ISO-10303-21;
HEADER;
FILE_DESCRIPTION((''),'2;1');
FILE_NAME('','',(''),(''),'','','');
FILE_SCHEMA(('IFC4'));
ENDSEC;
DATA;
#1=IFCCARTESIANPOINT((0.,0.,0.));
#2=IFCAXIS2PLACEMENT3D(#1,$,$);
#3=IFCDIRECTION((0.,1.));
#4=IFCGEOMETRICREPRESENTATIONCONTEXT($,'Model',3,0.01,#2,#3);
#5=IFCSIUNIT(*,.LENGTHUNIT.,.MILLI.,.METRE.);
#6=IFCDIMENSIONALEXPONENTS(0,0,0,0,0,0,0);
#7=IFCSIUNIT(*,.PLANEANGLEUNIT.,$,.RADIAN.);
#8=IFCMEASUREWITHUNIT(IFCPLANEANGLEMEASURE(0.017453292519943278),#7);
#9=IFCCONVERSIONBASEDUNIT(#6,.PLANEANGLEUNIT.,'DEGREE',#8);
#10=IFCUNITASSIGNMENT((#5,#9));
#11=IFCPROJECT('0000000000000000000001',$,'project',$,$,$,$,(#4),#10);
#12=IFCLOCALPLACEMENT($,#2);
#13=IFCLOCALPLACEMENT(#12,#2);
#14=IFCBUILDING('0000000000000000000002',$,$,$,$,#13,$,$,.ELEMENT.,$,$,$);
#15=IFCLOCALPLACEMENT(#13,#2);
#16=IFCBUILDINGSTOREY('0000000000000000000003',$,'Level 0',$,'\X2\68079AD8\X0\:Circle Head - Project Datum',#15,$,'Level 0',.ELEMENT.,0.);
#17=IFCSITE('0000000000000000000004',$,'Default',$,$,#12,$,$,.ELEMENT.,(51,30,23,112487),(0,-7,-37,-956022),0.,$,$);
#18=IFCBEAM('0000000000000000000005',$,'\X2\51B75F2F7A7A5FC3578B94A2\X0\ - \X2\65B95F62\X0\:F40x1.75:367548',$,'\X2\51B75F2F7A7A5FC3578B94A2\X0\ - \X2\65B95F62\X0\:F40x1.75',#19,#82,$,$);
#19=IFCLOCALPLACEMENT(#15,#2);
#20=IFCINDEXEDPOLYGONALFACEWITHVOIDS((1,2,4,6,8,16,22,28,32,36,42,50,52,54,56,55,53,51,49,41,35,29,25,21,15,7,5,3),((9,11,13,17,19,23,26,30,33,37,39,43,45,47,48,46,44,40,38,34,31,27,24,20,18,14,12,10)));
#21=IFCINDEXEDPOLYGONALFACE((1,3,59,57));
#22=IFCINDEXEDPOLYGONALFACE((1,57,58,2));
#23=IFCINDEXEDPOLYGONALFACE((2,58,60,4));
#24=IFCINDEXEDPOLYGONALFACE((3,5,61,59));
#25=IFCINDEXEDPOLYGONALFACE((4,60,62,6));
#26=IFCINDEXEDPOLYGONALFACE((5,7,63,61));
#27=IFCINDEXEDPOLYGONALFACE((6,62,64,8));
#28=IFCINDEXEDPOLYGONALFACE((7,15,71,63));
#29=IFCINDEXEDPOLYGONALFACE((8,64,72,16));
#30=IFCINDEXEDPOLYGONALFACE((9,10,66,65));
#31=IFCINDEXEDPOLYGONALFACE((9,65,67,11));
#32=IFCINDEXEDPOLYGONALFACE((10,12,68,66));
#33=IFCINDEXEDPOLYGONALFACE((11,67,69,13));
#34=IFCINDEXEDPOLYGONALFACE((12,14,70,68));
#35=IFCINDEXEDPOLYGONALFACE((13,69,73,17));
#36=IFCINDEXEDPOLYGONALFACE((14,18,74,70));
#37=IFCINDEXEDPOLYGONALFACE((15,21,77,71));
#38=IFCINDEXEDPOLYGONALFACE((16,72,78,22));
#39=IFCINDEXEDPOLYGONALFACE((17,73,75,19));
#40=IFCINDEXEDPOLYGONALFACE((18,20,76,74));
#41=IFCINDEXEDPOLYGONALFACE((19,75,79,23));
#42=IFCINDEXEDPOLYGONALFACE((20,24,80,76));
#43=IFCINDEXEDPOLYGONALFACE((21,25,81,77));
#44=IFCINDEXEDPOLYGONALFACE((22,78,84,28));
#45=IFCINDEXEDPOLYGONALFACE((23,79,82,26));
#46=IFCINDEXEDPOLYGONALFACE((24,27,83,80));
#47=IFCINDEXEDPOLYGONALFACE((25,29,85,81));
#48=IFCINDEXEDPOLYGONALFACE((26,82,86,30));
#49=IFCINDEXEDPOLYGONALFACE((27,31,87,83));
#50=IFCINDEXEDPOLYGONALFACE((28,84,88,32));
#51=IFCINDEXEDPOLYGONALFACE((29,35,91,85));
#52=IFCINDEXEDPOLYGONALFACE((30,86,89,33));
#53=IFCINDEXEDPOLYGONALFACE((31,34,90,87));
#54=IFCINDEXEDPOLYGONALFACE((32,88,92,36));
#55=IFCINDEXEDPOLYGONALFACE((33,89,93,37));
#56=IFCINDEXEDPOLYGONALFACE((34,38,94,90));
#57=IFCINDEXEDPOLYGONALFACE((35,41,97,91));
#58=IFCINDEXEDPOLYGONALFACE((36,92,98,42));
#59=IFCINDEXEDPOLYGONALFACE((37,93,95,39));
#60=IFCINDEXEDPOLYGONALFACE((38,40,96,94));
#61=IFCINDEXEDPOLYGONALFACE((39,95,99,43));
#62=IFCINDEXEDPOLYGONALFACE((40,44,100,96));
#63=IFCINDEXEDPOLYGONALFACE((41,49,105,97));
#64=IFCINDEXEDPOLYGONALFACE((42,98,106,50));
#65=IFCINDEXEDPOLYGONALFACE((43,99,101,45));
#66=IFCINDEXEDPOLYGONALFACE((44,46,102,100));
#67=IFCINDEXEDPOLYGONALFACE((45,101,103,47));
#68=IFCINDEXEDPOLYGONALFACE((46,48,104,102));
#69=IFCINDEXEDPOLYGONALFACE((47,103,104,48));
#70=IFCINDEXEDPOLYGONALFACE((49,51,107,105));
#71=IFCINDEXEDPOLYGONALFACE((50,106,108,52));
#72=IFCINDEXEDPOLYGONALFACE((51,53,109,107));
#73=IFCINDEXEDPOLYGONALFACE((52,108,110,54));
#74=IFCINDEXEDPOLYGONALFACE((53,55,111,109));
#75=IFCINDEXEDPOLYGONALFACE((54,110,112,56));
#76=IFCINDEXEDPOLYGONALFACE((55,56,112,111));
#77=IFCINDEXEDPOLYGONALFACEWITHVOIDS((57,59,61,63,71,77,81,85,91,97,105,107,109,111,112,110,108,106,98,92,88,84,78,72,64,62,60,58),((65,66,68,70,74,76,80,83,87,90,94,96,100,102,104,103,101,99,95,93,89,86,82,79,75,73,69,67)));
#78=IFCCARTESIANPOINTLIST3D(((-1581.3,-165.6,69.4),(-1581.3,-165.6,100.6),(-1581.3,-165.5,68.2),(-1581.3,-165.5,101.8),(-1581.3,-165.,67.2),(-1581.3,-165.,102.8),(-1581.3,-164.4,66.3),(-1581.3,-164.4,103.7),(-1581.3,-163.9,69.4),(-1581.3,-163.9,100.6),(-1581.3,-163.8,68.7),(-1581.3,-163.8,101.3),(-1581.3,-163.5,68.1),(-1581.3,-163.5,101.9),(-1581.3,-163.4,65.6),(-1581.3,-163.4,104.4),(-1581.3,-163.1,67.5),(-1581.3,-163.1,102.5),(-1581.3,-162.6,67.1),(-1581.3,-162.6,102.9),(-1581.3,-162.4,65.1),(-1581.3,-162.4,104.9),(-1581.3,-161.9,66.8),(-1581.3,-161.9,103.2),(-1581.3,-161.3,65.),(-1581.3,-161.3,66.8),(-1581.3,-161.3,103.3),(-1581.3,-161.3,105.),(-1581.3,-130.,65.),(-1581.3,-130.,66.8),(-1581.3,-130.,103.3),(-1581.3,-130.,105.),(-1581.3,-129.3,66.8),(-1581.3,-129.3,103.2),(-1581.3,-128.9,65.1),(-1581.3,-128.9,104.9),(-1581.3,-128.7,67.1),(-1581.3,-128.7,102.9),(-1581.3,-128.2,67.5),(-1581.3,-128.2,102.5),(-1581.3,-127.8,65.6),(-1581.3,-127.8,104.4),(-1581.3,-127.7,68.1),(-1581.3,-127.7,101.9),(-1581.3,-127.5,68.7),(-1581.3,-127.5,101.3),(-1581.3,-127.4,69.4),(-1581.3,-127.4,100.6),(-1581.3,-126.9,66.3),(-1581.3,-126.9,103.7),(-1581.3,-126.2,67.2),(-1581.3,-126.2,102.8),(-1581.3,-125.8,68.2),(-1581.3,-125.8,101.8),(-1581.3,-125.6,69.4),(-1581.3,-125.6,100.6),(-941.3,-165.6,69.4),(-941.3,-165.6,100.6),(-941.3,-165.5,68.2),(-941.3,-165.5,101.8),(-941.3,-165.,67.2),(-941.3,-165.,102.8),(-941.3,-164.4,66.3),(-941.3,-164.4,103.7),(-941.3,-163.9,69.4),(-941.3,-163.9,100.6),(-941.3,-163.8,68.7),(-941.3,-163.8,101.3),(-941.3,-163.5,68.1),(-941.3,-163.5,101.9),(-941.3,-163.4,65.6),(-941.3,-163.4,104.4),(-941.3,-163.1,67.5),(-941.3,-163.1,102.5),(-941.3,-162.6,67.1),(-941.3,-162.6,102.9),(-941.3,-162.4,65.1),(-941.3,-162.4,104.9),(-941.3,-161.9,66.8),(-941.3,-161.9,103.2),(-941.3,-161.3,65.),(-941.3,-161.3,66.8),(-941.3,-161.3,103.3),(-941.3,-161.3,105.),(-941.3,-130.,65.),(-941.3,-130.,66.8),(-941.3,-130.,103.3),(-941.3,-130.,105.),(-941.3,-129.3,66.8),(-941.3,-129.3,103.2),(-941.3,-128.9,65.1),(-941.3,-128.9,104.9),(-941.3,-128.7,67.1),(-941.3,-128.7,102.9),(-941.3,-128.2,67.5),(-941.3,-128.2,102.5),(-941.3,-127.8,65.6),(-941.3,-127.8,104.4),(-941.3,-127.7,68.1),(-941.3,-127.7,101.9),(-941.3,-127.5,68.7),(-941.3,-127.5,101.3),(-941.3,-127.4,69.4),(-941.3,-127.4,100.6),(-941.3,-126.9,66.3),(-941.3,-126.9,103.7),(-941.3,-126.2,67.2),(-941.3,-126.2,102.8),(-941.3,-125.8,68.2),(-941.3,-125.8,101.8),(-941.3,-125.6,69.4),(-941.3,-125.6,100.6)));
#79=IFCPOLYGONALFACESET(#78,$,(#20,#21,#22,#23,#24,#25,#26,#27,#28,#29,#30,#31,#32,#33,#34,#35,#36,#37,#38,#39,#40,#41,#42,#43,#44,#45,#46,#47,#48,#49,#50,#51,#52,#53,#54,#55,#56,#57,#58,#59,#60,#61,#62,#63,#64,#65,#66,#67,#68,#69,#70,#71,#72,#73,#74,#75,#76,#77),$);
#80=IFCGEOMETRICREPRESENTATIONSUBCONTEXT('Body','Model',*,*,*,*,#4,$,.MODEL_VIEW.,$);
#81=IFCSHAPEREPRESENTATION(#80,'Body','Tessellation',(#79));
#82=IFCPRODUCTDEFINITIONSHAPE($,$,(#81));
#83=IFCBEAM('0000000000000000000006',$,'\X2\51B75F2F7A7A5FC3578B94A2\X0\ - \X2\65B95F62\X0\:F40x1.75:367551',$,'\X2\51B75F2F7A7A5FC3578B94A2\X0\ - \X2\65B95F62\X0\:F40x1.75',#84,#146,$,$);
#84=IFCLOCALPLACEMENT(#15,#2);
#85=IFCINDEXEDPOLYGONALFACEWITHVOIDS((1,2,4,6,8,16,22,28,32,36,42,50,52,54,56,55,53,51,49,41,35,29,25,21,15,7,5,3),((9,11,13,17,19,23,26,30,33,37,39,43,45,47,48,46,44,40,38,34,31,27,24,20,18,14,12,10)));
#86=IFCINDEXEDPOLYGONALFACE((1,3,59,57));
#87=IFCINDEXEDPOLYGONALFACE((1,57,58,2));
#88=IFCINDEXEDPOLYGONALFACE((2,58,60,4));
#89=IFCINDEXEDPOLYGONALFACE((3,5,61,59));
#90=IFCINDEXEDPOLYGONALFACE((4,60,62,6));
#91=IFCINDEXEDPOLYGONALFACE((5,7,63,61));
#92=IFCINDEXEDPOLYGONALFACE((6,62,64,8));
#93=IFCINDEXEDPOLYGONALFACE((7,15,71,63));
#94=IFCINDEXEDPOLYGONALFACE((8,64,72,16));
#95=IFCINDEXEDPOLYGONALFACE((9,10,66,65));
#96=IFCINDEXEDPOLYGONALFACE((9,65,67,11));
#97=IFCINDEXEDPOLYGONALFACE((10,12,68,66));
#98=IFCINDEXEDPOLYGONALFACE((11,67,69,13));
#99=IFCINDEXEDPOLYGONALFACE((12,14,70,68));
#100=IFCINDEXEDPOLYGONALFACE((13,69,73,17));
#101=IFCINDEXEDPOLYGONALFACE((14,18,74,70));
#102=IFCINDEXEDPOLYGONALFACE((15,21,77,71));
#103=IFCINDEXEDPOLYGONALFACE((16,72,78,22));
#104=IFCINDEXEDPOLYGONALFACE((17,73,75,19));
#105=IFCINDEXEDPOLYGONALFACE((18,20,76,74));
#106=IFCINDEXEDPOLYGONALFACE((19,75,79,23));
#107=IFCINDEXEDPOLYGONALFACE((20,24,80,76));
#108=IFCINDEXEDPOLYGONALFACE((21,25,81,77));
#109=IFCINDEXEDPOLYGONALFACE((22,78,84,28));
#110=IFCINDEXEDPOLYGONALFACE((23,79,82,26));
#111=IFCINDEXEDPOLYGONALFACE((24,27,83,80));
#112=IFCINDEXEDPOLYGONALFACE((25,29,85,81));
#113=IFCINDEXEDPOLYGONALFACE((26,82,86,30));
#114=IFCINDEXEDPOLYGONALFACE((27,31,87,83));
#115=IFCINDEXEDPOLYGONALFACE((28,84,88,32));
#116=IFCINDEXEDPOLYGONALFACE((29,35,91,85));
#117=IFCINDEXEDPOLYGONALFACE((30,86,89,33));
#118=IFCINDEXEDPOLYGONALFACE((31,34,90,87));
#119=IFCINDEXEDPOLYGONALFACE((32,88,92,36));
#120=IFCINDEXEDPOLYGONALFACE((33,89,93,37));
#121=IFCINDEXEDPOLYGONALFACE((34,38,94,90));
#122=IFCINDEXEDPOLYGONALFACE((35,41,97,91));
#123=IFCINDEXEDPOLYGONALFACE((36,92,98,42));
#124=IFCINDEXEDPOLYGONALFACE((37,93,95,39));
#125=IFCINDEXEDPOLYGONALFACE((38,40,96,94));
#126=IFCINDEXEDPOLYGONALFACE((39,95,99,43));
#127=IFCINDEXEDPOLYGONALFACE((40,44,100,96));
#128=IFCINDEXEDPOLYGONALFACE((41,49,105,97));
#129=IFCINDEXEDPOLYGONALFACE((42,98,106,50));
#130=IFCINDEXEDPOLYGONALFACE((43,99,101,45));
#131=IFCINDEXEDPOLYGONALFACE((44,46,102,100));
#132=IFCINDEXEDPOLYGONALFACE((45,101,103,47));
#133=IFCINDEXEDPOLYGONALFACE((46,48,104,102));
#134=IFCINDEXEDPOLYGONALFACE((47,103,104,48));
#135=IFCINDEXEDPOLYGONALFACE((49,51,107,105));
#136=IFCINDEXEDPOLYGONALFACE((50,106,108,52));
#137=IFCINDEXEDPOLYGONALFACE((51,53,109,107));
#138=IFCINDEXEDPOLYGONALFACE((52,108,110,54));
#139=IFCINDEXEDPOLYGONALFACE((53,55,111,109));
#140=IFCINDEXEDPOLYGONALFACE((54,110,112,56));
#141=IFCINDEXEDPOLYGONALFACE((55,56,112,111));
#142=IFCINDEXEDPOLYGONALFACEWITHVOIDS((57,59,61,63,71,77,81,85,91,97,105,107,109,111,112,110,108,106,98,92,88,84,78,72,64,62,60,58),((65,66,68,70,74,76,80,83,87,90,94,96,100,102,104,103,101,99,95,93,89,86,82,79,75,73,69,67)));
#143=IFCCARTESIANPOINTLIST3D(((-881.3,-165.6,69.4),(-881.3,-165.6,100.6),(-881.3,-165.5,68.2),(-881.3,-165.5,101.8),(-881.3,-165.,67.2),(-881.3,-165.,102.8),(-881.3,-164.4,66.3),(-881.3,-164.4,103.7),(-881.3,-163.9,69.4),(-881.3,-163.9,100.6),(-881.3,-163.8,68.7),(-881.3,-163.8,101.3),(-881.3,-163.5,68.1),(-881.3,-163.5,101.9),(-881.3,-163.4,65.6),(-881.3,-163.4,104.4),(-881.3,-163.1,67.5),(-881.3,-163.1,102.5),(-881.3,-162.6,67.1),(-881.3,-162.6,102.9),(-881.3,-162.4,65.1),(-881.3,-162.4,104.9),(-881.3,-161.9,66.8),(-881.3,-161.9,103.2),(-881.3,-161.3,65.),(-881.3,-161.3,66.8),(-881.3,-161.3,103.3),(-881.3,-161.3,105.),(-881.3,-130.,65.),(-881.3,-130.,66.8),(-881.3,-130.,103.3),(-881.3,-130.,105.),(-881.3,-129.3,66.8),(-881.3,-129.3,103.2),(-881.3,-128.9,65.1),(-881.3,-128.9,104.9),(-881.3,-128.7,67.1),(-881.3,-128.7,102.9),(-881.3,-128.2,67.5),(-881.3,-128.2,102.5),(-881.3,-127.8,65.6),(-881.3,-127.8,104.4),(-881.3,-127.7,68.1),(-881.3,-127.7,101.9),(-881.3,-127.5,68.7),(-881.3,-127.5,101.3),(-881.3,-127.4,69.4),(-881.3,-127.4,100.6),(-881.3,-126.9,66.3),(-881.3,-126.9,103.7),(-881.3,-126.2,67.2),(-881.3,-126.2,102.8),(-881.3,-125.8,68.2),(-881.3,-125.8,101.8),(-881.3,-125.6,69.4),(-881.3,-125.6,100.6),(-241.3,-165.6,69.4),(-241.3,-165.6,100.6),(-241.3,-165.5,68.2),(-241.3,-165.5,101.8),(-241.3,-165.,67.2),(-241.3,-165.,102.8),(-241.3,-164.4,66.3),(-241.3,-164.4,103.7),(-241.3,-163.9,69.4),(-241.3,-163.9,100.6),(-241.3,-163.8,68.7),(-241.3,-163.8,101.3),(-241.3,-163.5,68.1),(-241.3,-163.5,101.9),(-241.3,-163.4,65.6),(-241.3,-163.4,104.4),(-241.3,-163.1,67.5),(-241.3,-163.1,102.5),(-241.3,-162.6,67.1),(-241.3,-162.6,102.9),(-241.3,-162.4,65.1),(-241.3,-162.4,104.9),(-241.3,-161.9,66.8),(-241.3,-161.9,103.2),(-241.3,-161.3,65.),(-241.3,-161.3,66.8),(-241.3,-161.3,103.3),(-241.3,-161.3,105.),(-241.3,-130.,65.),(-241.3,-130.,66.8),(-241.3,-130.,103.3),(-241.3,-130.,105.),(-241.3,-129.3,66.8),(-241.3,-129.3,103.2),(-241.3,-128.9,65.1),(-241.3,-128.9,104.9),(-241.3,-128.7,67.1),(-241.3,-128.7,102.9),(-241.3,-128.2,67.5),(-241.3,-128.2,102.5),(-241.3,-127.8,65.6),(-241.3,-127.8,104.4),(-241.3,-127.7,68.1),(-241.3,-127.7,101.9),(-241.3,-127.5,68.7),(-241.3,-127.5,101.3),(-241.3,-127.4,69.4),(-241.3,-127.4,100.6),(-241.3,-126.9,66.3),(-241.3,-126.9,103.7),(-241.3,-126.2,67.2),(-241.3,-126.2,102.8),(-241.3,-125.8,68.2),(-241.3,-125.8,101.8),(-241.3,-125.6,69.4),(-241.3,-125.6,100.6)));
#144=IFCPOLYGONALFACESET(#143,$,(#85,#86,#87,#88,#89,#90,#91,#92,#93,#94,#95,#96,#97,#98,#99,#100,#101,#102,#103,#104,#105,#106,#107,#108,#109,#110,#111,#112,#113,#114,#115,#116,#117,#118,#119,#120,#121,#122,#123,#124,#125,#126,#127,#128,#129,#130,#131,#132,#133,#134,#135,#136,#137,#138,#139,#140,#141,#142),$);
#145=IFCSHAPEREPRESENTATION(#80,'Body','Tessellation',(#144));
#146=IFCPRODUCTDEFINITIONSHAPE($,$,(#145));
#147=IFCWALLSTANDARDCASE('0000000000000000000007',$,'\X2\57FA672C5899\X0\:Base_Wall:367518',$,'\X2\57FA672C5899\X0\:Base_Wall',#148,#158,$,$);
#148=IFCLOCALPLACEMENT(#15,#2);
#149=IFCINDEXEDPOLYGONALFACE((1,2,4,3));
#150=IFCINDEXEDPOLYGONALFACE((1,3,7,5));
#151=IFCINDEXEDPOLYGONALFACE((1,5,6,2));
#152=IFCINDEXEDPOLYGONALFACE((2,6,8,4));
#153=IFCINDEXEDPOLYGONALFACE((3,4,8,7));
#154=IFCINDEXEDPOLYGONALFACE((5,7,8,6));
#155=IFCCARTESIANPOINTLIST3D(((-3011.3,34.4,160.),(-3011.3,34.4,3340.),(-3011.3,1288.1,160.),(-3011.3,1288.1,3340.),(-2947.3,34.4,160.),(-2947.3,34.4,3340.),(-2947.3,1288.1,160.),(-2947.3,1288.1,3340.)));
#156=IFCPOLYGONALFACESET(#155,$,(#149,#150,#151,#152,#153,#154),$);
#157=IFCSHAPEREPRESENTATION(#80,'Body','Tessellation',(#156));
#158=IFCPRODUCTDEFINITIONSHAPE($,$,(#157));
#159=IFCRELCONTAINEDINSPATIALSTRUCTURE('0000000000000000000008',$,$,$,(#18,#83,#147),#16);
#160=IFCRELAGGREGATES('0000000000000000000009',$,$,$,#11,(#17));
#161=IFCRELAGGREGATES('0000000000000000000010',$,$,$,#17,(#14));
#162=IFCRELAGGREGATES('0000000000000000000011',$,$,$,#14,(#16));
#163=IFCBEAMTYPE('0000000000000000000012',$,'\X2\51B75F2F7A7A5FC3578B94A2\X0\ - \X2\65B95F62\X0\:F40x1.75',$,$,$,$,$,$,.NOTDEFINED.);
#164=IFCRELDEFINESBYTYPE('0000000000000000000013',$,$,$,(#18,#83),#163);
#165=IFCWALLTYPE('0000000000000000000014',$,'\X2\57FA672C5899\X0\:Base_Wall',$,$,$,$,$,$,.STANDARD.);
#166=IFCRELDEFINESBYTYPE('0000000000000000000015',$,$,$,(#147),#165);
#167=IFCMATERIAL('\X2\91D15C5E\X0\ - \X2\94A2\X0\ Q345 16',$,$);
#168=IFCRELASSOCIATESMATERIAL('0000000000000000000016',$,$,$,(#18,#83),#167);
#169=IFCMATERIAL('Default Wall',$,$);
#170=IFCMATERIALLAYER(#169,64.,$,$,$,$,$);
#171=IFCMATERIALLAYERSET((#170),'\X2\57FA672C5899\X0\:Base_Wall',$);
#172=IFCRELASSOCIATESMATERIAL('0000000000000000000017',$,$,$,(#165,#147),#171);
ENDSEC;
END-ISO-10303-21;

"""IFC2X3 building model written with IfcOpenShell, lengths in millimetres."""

from ifc_helpers import new_model, entity, si_unit, converted_unit, direction, frame, frame_2d, origin, place, context, subcontext, project, spatial, polyline, circle_curve, parameter, trimmed, segment, composite_curve, rectangle, outline, extrude, material, layer, layer_set, layer_usage, type_object, element, save


model = new_model("IFC2X3")

# Units and contexts
model_context = context("Model", 3, precision=0.01, world=origin(), true_north=direction((0.0, 1.0)))
body_context = subcontext(model_context, "Body", "Model", "MODEL_VIEW")
ifc_project = project(units=[si_unit("LENGTHUNIT", "METRE", prefix="MILLI"), converted_unit("PLANEANGLEUNIT", "DEGREE", entity("IfcPlaneAngleMeasure", 0.017453292519943278), si_unit("PLANEANGLEUNIT", "RADIAN"), dimensions=[0, 0, 0, 0, 0, 0, 0])], contexts=[model_context])

# Site, building, storey
site_placement = place(None, origin())
site = spatial("IfcSite", under=ifc_project, at=site_placement, Name="Default", CompositionType="ELEMENT", RefLatitude=(51, 30, 23, 112487), RefLongitude=(0, -7, -37, -956022), RefElevation=0.0)
building_placement = place(site_placement, origin())
building = spatial("IfcBuilding", under=site, at=building_placement, CompositionType="ELEMENT")
storey_placement = place(building_placement, origin())
storey = spatial("IfcBuildingStorey", under=building, at=storey_placement, Name="Level 0", ObjectType="标高:Circle Head - Project Datum", LongName="Level 0", CompositionType="ELEMENT", Elevation=0.0)

# Beams
ifc_material_1 = material(Name="金属 - 钢 Q345 16")
beam_type_1 = type_object("IfcBeamType", Name="冷弯空心型钢 - 方形:F40x1.75", PredefinedType="NOTDEFINED")
beam_1_placement = place(storey_placement, frame((-1546.3, -145.6, 105.0)))
element("IfcBeam", 1, at=beam_1_placement, inside=storey, type_object=beam_type_1, material=ifc_material_1, Name="冷弯空心型钢 - 方形:F40x1.75:367548", ObjectType="冷弯空心型钢 - 方形:F40x1.75", context=body_context, shape_type="SweptSolid", body=[
    extrude(outline(composite_curve([segment(trimmed(circle_curve(frame_2d((-15.6, 15.6), x_axis=(1.0, 0.0)), 4.4), [parameter(90.0)], [parameter(180.0)], True, "PARAMETER"), True, "CONTINUOUS"), segment(polyline([(-20.0, 15.6), (-20.0, -15.6)]), True, "CONTINUOUS"), segment(trimmed(circle_curve(frame_2d((-15.6, -15.6), x_axis=(1.0, 0.0)), 4.4), [parameter(180.0)], [parameter(270.0)], True, "PARAMETER"), True, "CONTINUOUS"), segment(polyline([(-15.6, -20.0), (15.6, -20.0)]), True, "CONTINUOUS"), segment(trimmed(circle_curve(frame_2d((15.6, -15.6), x_axis=(1.0, 0.0)), 4.4), [parameter(270.0)], [parameter(0.0)], True, "PARAMETER"), True, "CONTINUOUS"), segment(polyline([(20.0, -15.6), (20.0, 15.6)]), True, "CONTINUOUS"), segment(trimmed(circle_curve(frame_2d((15.6, 15.6), x_axis=(1.0, 0.0)), 4.4), [parameter(0.0)], [parameter(90.0)], True, "PARAMETER"), True, "CONTINUOUS"), segment(polyline([(15.6, 20.0), (-15.6, 20.0)]), True, "CONTINUOUS")], self_intersect=False), holes=[composite_curve([segment(polyline([(-15.6, 18.3), (15.6, 18.3)]), True, "CONTINUOUS"), segment(trimmed(circle_curve(frame_2d((15.6, 15.6), x_axis=(1.0, 0.0)), 2.6), [parameter(0.0)], [parameter(90.0)], True, "PARAMETER"), False, "CONTINUOUS"), segment(polyline([(18.2, 15.6), (18.2, -15.6)]), True, "CONTINUOUS"), segment(trimmed(circle_curve(frame_2d((15.6, -15.6), x_axis=(1.0, 0.0)), 2.6), [parameter(270.0)], [parameter(360.0)], True, "PARAMETER"), False, "CONTINUOUS"), segment(polyline([(15.6, -18.2), (-15.6, -18.2)]), True, "CONTINUOUS"), segment(trimmed(circle_curve(frame_2d((-15.6, -15.6), x_axis=(1.0, 0.0)), 2.6), [parameter(180.0)], [parameter(270.0)], True, "PARAMETER"), False, "CONTINUOUS"), segment(polyline([(-18.3, -15.6), (-18.3, 15.6)]), True, "CONTINUOUS"), segment(trimmed(circle_curve(frame_2d((-15.6, 15.6), x_axis=(1.0, 0.0)), 2.6), [parameter(90.0)], [parameter(180.0)], True, "PARAMETER"), False, "CONTINUOUS")], self_intersect=False)]), frame((-35.0, 0.0, -20.0), z_axis=(1.0, 0.0, 0.0), x_axis=(0.0, 1.0, 0.0)), (0.0, 0.0, 1.0), 640.0),
])
beam_2_placement = place(storey_placement, frame((-846.3, -145.6, 105.0)))
element("IfcBeam", 2, at=beam_2_placement, inside=storey, type_object=beam_type_1, material=ifc_material_1, Name="冷弯空心型钢 - 方形:F40x1.75:367551", ObjectType="冷弯空心型钢 - 方形:F40x1.75", context=body_context, shape_type="SweptSolid", body=[
    extrude(outline(composite_curve([segment(trimmed(circle_curve(frame_2d((-15.6, 15.6), x_axis=(1.0, 0.0)), 4.4), [parameter(90.0)], [parameter(180.0)], True, "PARAMETER"), True, "CONTINUOUS"), segment(polyline([(-20.0, 15.6), (-20.0, -15.6)]), True, "CONTINUOUS"), segment(trimmed(circle_curve(frame_2d((-15.6, -15.6), x_axis=(1.0, 0.0)), 4.4), [parameter(180.0)], [parameter(270.0)], True, "PARAMETER"), True, "CONTINUOUS"), segment(polyline([(-15.6, -20.0), (15.6, -20.0)]), True, "CONTINUOUS"), segment(trimmed(circle_curve(frame_2d((15.6, -15.6), x_axis=(1.0, 0.0)), 4.4), [parameter(270.0)], [parameter(0.0)], True, "PARAMETER"), True, "CONTINUOUS"), segment(polyline([(20.0, -15.6), (20.0, 15.6)]), True, "CONTINUOUS"), segment(trimmed(circle_curve(frame_2d((15.6, 15.6), x_axis=(1.0, 0.0)), 4.4), [parameter(0.0)], [parameter(90.0)], True, "PARAMETER"), True, "CONTINUOUS"), segment(polyline([(15.6, 20.0), (-15.6, 20.0)]), True, "CONTINUOUS")], self_intersect=False), holes=[composite_curve([segment(polyline([(-15.6, 18.3), (15.6, 18.3)]), True, "CONTINUOUS"), segment(trimmed(circle_curve(frame_2d((15.6, 15.6), x_axis=(1.0, 0.0)), 2.6), [parameter(0.0)], [parameter(90.0)], True, "PARAMETER"), False, "CONTINUOUS"), segment(polyline([(18.2, 15.6), (18.2, -15.6)]), True, "CONTINUOUS"), segment(trimmed(circle_curve(frame_2d((15.6, -15.6), x_axis=(1.0, 0.0)), 2.6), [parameter(270.0)], [parameter(360.0)], True, "PARAMETER"), False, "CONTINUOUS"), segment(polyline([(15.6, -18.2), (-15.6, -18.2)]), True, "CONTINUOUS"), segment(trimmed(circle_curve(frame_2d((-15.6, -15.6), x_axis=(1.0, 0.0)), 2.6), [parameter(180.0)], [parameter(270.0)], True, "PARAMETER"), False, "CONTINUOUS"), segment(polyline([(-18.3, -15.6), (-18.3, 15.6)]), True, "CONTINUOUS"), segment(trimmed(circle_curve(frame_2d((-15.6, 15.6), x_axis=(1.0, 0.0)), 2.6), [parameter(90.0)], [parameter(180.0)], True, "PARAMETER"), False, "CONTINUOUS")], self_intersect=False)]), frame((-35.0, 0.0, -20.0), z_axis=(1.0, 0.0, 0.0), x_axis=(0.0, 1.0, 0.0)), (0.0, 0.0, 1.0), 640.0),
])

# Wall
ifc_material_2 = material(Name="Default Wall")
ifc_layer_1 = layer(ifc_material_2, 64.0)
ifc_layer_set_1 = layer_set([ifc_layer_1], Name="基本墙:Base_Wall")
ifc_layer_usage_1 = layer_usage(ifc_layer_set_1, "AXIS2", "NEGATIVE", 32.0)
wall_type_1 = type_object("IfcWallType", Name="基本墙:Base_Wall", PredefinedType="STANDARD", material=ifc_layer_set_1)
wall_1_placement = place(storey_placement, frame((-2979.3, 1288.1, 160.0), z_axis=(0.0, 0.0, 1.0), x_axis=(0.0, -1.0, 0.0)))
element("IfcWallStandardCase", 3, at=wall_1_placement, inside=storey, type_object=wall_type_1, material=ifc_layer_usage_1, Name="基本墙:Base_Wall:367518", ObjectType="基本墙:Base_Wall", context=body_context, shape_type="SweptSolid", body=[
    extrude(rectangle(XDim=1253.8, YDim=64.0, at=frame_2d((626.9, 0.0), x_axis=(-1.0, 0.0))), origin(), (0.0, 0.0, 1.0), 3180.0),
])

save(model, "model.ifc")
